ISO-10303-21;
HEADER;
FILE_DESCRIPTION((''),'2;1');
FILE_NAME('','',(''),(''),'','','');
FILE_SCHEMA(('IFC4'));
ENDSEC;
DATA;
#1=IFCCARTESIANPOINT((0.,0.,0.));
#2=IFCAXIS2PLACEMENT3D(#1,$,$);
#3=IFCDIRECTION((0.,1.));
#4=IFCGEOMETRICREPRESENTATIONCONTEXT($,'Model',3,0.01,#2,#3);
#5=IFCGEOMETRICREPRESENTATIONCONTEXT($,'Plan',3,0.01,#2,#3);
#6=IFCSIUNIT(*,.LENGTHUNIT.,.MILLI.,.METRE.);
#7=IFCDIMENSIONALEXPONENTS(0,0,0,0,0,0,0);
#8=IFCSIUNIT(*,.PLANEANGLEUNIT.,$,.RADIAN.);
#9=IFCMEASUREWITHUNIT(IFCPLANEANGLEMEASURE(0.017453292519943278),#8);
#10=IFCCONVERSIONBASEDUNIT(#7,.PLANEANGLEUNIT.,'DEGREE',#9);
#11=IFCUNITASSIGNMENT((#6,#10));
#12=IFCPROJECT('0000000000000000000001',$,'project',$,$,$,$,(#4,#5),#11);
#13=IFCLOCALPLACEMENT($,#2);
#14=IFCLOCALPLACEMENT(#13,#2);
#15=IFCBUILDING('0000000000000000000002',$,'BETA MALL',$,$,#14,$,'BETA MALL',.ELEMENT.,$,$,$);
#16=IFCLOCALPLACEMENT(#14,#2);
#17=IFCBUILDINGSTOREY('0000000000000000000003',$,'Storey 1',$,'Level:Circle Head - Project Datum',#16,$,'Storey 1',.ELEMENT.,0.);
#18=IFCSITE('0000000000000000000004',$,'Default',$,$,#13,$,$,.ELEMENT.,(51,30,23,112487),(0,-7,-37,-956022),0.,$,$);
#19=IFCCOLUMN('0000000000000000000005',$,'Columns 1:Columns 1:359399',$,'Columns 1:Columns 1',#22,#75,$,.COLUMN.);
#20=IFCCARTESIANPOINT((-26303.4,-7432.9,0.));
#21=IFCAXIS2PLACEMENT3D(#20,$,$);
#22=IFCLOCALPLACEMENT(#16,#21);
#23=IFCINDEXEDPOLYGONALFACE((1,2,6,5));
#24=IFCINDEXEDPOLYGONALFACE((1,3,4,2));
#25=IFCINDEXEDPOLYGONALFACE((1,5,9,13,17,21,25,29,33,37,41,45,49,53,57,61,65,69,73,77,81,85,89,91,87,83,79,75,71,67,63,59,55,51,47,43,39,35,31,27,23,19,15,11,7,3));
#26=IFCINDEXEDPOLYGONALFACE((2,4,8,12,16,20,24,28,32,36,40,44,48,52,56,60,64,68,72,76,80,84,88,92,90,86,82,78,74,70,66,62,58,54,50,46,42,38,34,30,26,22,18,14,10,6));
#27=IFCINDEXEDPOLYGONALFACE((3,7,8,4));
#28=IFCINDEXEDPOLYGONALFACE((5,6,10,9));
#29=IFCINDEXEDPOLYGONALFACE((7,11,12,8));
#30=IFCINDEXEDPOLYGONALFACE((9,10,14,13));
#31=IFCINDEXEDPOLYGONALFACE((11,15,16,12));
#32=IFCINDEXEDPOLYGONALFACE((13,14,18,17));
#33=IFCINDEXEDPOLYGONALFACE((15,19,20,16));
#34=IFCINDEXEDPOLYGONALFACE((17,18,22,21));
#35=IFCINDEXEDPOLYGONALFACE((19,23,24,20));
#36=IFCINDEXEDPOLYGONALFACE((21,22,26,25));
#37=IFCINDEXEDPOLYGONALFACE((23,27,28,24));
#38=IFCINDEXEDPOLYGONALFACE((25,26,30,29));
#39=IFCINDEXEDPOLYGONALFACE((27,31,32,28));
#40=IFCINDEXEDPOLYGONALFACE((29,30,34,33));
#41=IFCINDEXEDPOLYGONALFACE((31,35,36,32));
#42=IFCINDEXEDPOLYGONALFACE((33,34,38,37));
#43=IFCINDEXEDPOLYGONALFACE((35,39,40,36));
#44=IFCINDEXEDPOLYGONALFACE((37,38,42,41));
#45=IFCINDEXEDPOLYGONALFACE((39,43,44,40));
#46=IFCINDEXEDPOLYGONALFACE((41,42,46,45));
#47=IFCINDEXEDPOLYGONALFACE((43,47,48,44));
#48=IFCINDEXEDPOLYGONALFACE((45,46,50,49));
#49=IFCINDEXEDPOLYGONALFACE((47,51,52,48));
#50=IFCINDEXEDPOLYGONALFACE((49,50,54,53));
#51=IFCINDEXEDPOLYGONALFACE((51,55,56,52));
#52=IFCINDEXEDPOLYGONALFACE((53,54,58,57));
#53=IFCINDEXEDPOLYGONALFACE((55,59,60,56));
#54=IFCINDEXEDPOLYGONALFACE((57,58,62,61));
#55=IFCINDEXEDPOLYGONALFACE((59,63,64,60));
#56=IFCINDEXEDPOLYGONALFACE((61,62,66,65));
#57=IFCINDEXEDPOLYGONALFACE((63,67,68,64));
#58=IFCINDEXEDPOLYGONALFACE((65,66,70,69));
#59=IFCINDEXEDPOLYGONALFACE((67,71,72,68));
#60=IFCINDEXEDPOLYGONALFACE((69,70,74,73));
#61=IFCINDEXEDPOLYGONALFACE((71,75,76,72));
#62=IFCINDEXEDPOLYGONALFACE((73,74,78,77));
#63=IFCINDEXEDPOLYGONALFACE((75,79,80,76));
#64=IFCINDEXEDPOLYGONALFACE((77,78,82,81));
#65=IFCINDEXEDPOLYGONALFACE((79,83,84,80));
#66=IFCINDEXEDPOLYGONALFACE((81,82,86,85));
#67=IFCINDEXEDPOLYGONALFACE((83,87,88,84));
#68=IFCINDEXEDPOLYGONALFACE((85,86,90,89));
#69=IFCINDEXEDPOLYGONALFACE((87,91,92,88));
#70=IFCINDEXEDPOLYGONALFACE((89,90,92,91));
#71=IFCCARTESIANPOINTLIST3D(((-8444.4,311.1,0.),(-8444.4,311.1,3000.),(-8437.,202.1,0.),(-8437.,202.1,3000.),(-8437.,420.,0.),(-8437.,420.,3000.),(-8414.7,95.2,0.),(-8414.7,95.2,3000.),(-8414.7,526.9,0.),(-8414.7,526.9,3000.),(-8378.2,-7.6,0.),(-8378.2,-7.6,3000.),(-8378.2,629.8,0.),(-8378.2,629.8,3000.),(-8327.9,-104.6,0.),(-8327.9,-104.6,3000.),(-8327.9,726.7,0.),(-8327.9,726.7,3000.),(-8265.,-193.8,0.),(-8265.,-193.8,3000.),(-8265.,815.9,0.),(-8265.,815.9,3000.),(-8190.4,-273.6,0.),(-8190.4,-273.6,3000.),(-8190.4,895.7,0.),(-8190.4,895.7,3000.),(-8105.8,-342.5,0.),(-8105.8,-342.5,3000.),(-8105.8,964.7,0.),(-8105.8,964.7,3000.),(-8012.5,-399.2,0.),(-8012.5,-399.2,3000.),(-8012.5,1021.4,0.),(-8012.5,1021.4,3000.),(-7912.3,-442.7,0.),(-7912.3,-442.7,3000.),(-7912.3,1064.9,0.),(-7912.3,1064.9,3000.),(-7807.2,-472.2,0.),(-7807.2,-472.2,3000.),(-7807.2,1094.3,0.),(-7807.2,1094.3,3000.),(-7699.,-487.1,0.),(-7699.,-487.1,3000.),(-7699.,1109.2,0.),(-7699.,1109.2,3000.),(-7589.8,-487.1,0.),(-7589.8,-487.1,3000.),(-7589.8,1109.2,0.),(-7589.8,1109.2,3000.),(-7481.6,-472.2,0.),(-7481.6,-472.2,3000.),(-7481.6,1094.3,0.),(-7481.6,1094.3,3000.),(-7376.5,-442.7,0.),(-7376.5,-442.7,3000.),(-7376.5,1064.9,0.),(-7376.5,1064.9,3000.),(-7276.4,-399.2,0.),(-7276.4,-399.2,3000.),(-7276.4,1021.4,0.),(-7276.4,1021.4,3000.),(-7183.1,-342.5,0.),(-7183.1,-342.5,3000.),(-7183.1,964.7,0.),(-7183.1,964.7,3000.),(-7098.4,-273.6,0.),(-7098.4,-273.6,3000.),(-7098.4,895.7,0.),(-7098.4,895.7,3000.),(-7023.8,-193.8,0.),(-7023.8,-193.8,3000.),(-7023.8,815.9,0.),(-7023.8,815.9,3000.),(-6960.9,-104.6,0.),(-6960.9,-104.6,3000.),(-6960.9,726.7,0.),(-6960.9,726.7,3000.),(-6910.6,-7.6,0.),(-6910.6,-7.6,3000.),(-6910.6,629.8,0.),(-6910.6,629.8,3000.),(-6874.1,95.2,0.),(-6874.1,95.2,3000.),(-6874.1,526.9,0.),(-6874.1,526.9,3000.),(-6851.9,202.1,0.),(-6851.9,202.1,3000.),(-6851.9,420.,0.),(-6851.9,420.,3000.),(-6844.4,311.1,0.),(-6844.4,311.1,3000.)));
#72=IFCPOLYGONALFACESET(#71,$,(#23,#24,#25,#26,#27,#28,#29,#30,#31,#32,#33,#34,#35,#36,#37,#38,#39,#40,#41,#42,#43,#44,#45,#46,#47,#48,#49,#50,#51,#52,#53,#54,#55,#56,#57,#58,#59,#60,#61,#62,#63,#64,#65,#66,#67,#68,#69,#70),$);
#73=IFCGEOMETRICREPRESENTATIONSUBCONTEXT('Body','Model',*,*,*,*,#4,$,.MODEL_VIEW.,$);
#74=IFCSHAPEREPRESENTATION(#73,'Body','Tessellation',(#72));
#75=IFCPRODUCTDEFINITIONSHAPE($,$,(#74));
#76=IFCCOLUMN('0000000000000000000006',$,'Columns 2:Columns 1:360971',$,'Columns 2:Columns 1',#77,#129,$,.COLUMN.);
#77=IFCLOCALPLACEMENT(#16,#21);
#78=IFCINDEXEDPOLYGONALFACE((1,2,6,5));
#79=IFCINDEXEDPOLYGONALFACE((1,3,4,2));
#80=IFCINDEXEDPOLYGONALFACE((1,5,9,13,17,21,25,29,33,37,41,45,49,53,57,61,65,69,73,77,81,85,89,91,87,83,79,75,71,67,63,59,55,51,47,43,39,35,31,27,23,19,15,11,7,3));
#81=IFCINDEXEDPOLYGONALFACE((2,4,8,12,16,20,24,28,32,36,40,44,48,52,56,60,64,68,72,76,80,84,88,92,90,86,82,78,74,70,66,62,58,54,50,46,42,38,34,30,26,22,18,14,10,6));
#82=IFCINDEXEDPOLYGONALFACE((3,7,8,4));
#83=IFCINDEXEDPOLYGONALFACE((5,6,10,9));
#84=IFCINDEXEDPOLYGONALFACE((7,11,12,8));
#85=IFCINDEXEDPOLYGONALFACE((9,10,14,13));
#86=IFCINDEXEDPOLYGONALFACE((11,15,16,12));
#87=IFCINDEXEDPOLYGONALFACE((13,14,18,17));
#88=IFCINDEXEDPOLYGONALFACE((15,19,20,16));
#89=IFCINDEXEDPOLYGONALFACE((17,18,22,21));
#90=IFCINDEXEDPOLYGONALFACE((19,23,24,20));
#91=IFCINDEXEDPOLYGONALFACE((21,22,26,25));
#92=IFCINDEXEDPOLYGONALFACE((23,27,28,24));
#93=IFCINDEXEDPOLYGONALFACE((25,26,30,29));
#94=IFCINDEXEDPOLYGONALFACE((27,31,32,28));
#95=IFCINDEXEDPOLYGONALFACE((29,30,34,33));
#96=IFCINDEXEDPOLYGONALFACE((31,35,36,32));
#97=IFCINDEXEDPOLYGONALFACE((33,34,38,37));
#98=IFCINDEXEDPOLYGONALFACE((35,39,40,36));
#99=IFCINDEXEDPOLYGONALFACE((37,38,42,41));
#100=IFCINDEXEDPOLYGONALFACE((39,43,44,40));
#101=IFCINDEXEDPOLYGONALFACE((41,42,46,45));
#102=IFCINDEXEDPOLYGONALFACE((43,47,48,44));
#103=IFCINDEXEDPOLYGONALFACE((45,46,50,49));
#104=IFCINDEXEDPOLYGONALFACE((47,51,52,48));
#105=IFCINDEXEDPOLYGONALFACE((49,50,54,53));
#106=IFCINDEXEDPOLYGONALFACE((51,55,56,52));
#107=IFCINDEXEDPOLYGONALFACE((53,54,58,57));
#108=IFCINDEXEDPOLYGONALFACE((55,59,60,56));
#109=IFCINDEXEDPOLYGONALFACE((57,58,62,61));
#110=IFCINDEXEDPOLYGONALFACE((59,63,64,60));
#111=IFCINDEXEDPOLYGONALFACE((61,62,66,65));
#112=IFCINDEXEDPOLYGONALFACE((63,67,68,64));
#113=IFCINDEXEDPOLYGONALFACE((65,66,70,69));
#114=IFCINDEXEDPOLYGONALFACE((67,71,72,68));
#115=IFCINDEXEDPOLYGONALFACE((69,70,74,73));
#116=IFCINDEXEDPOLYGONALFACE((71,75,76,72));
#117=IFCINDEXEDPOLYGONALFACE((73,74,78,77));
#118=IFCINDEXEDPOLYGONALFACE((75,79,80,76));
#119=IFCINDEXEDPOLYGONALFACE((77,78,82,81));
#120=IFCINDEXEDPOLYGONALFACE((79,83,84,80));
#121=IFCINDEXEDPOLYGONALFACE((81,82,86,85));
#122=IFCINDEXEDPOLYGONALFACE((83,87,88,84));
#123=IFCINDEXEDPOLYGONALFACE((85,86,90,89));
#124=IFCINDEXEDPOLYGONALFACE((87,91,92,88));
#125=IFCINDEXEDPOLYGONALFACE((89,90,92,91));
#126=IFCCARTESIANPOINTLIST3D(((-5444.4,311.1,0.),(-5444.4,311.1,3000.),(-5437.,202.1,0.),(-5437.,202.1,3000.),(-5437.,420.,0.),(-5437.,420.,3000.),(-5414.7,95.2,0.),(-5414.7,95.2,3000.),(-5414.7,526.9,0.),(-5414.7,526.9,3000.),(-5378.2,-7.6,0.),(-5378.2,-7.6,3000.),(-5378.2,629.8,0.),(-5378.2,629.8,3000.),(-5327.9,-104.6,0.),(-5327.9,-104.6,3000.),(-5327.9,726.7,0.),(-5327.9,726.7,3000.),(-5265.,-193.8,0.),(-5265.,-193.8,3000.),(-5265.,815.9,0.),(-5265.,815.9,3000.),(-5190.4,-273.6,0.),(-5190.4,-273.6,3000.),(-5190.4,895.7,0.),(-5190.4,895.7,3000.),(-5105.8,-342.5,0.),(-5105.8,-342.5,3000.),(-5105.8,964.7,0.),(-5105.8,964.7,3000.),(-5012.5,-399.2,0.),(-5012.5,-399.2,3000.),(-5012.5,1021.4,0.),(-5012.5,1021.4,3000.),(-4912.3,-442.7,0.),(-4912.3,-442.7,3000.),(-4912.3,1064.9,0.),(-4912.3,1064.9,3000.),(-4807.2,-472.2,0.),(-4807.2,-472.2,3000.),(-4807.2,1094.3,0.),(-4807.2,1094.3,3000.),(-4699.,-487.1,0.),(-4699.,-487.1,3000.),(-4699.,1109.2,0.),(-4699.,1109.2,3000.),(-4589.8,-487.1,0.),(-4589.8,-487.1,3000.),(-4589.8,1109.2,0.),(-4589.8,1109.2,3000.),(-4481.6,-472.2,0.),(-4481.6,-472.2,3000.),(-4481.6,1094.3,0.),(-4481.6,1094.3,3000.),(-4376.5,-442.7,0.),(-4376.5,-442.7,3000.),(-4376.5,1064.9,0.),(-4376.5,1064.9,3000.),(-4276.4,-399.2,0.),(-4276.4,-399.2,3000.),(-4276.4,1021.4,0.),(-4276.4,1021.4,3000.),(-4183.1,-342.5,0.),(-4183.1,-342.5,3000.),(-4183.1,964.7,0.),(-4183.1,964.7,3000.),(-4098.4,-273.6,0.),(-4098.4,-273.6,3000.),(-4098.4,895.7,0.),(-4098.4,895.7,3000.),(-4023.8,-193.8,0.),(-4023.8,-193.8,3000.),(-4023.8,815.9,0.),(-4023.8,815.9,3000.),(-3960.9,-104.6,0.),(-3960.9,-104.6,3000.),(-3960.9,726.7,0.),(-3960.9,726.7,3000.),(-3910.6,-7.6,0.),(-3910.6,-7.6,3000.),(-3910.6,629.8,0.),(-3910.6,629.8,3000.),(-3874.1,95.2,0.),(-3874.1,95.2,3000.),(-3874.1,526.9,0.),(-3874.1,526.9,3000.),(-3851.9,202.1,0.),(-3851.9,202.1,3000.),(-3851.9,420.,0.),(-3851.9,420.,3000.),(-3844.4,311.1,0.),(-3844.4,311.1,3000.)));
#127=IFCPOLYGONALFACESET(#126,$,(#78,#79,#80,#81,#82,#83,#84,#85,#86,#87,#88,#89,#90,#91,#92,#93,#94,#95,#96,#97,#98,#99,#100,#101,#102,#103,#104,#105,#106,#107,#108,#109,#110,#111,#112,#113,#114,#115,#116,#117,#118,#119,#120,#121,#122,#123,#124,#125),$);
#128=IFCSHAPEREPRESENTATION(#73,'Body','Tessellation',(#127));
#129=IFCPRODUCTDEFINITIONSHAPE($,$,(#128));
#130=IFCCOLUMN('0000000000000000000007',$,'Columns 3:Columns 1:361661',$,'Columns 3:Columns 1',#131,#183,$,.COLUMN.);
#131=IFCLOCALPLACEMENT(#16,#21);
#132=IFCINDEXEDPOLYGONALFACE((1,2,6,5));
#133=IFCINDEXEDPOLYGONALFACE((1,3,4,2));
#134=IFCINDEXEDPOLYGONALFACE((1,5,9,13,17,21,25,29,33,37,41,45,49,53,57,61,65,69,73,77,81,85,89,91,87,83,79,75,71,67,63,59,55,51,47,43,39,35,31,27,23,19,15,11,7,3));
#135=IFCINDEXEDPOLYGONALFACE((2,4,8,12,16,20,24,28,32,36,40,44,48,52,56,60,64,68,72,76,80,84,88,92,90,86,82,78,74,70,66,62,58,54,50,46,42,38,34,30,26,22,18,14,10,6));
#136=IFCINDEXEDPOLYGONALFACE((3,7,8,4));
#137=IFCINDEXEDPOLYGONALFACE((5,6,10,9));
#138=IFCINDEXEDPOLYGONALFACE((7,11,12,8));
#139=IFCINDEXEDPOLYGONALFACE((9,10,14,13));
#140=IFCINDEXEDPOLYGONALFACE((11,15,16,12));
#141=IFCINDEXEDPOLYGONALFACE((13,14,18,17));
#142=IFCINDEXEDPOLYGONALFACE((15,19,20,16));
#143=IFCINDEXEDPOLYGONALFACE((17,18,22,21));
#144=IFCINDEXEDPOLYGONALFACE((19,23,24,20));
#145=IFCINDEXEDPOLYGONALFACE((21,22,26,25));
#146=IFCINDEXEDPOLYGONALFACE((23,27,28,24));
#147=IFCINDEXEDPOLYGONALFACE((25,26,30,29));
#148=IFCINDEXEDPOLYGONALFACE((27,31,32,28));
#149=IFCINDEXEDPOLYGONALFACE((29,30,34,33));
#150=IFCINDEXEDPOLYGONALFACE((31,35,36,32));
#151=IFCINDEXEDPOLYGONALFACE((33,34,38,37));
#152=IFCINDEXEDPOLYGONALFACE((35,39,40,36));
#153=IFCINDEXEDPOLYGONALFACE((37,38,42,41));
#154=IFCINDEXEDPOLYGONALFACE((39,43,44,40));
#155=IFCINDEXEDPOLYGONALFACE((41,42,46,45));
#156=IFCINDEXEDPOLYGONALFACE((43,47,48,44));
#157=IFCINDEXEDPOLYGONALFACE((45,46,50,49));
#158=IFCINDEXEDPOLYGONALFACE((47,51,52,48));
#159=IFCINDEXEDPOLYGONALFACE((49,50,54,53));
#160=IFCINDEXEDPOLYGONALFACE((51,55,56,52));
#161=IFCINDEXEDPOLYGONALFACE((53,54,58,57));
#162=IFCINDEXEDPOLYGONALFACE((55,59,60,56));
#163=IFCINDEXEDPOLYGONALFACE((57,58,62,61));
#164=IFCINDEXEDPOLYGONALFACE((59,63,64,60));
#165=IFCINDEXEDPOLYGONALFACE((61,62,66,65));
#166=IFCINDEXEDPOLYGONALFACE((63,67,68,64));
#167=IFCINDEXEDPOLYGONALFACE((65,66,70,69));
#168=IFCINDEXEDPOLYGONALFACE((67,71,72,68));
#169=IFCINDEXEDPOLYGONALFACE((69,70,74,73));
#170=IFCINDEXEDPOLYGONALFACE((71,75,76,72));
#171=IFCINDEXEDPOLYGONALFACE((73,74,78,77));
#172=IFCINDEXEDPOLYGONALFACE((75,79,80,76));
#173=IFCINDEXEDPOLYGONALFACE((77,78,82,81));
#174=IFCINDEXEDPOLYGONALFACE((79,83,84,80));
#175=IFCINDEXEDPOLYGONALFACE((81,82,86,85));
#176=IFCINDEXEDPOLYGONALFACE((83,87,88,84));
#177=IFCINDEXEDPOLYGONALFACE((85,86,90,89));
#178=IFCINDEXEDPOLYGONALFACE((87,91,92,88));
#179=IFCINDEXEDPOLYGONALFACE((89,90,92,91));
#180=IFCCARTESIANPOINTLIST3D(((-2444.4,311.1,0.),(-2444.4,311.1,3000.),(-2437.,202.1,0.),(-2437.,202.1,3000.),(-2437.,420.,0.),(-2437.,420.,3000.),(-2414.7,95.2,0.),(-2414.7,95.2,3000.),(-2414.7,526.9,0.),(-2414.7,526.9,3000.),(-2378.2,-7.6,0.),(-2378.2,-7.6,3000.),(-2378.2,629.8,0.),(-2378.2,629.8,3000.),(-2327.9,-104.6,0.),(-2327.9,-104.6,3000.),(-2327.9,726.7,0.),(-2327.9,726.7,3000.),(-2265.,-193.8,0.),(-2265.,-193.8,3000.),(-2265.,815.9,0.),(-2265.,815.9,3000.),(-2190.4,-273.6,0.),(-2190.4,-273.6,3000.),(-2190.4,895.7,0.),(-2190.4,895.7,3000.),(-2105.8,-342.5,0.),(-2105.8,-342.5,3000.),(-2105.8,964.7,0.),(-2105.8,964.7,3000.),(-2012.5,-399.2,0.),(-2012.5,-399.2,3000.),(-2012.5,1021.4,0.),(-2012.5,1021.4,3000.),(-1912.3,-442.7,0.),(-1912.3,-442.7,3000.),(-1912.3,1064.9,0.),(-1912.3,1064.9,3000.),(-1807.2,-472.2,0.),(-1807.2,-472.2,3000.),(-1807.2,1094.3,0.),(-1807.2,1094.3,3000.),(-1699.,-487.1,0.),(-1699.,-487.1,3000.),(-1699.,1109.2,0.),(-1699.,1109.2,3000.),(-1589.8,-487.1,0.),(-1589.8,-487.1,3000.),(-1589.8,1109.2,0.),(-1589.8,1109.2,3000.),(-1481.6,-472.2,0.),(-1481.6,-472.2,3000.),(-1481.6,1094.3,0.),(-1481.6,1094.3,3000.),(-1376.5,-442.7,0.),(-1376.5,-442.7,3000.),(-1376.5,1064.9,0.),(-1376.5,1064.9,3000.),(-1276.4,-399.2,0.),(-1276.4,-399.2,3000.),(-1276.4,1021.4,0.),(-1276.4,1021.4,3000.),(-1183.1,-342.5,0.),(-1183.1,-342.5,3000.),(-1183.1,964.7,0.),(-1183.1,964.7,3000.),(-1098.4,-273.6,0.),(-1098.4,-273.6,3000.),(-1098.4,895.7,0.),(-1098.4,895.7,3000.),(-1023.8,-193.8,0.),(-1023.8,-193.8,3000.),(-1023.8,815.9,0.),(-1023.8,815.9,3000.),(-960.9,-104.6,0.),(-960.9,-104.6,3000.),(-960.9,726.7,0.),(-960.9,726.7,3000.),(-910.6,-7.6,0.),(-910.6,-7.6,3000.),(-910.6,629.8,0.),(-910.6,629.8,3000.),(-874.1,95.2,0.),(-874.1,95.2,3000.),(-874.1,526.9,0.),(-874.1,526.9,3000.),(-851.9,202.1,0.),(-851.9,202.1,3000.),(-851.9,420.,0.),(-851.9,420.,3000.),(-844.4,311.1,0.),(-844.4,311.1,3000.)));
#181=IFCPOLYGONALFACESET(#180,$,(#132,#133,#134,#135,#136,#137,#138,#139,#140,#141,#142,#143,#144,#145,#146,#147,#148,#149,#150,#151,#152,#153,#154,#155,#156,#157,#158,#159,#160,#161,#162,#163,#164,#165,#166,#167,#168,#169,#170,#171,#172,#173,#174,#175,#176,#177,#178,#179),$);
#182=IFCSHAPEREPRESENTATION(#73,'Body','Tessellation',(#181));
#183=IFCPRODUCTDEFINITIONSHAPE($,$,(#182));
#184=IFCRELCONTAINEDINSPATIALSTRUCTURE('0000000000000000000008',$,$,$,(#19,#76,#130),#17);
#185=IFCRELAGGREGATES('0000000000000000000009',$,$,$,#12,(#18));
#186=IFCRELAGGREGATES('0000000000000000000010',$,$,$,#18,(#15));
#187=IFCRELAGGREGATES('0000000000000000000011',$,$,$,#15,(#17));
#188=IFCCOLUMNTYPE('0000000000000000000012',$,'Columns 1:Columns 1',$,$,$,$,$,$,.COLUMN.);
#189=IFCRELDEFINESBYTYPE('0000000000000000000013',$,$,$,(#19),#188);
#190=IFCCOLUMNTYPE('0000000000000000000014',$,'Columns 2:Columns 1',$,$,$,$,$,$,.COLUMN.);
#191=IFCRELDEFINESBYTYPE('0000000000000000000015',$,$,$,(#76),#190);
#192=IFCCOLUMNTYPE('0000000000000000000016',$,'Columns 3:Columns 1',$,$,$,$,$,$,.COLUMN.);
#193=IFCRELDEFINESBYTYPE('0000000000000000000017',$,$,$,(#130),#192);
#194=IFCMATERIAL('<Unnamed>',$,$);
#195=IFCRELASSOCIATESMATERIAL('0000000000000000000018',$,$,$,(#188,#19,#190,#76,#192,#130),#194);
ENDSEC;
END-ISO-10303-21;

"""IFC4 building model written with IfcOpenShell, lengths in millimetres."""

from ifc_helpers import new_model, entity, si_unit, converted_unit, direction, frame, origin, place, context, subcontext, project, spatial, arc, indexed_curve, outline, extrude, source, transform, mapped, material, type_object, type_shapes, element, save


model = new_model("IFC4")

# Units and contexts
model_context = context("Model", 3, precision=0.01, world=origin(), true_north=direction((0.0, 1.0)))
plan_context = context("Plan", 3, precision=0.01, world=origin(), true_north=direction((0.0, 1.0)))
body_context = subcontext(model_context, "Body", "Model", "MODEL_VIEW")
ifc_project = project(units=[si_unit("LENGTHUNIT", "METRE", prefix="MILLI"), converted_unit("PLANEANGLEUNIT", "DEGREE", entity("IfcPlaneAngleMeasure", 0.017453292519943278), si_unit("PLANEANGLEUNIT", "RADIAN"), dimensions=[0, 0, 0, 0, 0, 0, 0])], contexts=[model_context, plan_context])

# Site, building, storey
site_placement = place(None, origin())
site = spatial("IfcSite", under=ifc_project, at=site_placement, Name="Default", CompositionType="ELEMENT", RefLatitude=(51, 30, 23, 112487), RefLongitude=(0, -7, -37, -956022), RefElevation=0.0)
building_placement = place(site_placement, origin())
building = spatial("IfcBuilding", under=site, at=building_placement, Name="BETA MALL", LongName="BETA MALL", CompositionType="ELEMENT")
storey_placement = place(building_placement, origin())
storey = spatial("IfcBuildingStorey", under=building, at=storey_placement, Name="Storey 1", ObjectType="Level:Circle Head - Project Datum", LongName="Storey 1", CompositionType="ELEMENT", Elevation=0.0)

# Columns
ifc_material_1 = material(Name="<Unnamed>")
column_type_1 = type_object("IfcColumnType", Name="Columns 1:Columns 1", PredefinedType="COLUMN", material=ifc_material_1)
shared_shape_1 = source(origin(), body_context, "Body", "SweptSolid", [
    extrude(outline(indexed_curve([(-800.0, 0.0), (0.0, -800.0), (800.0, 0.0), (0.0, 800.0)], segments=[arc(1, 2, 3), arc(3, 4, 1)], self_intersect=False)), frame((-7644.4, 311.1, 0.0)), (0.0, 0.0, 1.0), 3000.0),
])
type_shapes(column_type_1, [shared_shape_1])
column_1_placement = place(storey_placement, frame((-26303.4, -7432.9, 0.0)))
element("IfcColumn", 1, at=column_1_placement, inside=storey, type_object=column_type_1, material=ifc_material_1, Name="Columns 1:Columns 1:359399", ObjectType="Columns 1:Columns 1", PredefinedType="COLUMN", context=body_context, shape_type="MappedRepresentation", body=[
    mapped(shared_shape_1, transform((0.0, 0.0, 0.0), scale=1.0)),
])
column_type_2 = type_object("IfcColumnType", Name="Columns 2:Columns 1", PredefinedType="COLUMN", material=ifc_material_1)
shared_shape_2 = source(origin(), body_context, "Body", "SweptSolid", [
    extrude(outline(indexed_curve([(-800.0, 0.0), (0.0, -800.0), (800.0, 0.0), (0.0, 800.0)], segments=[arc(1, 2, 3), arc(3, 4, 1)], self_intersect=False)), frame((-4644.4, 311.1, 0.0)), (0.0, 0.0, 1.0), 3000.0),
])
type_shapes(column_type_2, [shared_shape_2])
column_2_placement = place(storey_placement, frame((-26303.4, -7432.9, 0.0)))
element("IfcColumn", 2, at=column_2_placement, inside=storey, type_object=column_type_2, material=ifc_material_1, Name="Columns 2:Columns 1:360971", ObjectType="Columns 2:Columns 1", PredefinedType="COLUMN", context=body_context, shape_type="MappedRepresentation", body=[
    mapped(shared_shape_2, transform((0.0, 0.0, 0.0), scale=1.0)),
])
column_type_3 = type_object("IfcColumnType", Name="Columns 3:Columns 1", PredefinedType="COLUMN", material=ifc_material_1)
shared_shape_3 = source(origin(), body_context, "Body", "SweptSolid", [
    extrude(outline(indexed_curve([(-800.0, 0.0), (0.0, -800.0), (800.0, 0.0), (0.0, 800.0)], segments=[arc(1, 2, 3), arc(3, 4, 1)], self_intersect=False)), frame((-1644.4, 311.1, 0.0)), (0.0, 0.0, 1.0), 3000.0),
])
type_shapes(column_type_3, [shared_shape_3])
column_3_placement = place(storey_placement, frame((-26303.4, -7432.9, 0.0)))
element("IfcColumn", 3, at=column_3_placement, inside=storey, type_object=column_type_3, material=ifc_material_1, Name="Columns 3:Columns 1:361661", ObjectType="Columns 3:Columns 1", PredefinedType="COLUMN", context=body_context, shape_type="MappedRepresentation", body=[
    mapped(shared_shape_3, transform((0.0, 0.0, 0.0), scale=1.0)),
])

save(model, "model.ifc")
